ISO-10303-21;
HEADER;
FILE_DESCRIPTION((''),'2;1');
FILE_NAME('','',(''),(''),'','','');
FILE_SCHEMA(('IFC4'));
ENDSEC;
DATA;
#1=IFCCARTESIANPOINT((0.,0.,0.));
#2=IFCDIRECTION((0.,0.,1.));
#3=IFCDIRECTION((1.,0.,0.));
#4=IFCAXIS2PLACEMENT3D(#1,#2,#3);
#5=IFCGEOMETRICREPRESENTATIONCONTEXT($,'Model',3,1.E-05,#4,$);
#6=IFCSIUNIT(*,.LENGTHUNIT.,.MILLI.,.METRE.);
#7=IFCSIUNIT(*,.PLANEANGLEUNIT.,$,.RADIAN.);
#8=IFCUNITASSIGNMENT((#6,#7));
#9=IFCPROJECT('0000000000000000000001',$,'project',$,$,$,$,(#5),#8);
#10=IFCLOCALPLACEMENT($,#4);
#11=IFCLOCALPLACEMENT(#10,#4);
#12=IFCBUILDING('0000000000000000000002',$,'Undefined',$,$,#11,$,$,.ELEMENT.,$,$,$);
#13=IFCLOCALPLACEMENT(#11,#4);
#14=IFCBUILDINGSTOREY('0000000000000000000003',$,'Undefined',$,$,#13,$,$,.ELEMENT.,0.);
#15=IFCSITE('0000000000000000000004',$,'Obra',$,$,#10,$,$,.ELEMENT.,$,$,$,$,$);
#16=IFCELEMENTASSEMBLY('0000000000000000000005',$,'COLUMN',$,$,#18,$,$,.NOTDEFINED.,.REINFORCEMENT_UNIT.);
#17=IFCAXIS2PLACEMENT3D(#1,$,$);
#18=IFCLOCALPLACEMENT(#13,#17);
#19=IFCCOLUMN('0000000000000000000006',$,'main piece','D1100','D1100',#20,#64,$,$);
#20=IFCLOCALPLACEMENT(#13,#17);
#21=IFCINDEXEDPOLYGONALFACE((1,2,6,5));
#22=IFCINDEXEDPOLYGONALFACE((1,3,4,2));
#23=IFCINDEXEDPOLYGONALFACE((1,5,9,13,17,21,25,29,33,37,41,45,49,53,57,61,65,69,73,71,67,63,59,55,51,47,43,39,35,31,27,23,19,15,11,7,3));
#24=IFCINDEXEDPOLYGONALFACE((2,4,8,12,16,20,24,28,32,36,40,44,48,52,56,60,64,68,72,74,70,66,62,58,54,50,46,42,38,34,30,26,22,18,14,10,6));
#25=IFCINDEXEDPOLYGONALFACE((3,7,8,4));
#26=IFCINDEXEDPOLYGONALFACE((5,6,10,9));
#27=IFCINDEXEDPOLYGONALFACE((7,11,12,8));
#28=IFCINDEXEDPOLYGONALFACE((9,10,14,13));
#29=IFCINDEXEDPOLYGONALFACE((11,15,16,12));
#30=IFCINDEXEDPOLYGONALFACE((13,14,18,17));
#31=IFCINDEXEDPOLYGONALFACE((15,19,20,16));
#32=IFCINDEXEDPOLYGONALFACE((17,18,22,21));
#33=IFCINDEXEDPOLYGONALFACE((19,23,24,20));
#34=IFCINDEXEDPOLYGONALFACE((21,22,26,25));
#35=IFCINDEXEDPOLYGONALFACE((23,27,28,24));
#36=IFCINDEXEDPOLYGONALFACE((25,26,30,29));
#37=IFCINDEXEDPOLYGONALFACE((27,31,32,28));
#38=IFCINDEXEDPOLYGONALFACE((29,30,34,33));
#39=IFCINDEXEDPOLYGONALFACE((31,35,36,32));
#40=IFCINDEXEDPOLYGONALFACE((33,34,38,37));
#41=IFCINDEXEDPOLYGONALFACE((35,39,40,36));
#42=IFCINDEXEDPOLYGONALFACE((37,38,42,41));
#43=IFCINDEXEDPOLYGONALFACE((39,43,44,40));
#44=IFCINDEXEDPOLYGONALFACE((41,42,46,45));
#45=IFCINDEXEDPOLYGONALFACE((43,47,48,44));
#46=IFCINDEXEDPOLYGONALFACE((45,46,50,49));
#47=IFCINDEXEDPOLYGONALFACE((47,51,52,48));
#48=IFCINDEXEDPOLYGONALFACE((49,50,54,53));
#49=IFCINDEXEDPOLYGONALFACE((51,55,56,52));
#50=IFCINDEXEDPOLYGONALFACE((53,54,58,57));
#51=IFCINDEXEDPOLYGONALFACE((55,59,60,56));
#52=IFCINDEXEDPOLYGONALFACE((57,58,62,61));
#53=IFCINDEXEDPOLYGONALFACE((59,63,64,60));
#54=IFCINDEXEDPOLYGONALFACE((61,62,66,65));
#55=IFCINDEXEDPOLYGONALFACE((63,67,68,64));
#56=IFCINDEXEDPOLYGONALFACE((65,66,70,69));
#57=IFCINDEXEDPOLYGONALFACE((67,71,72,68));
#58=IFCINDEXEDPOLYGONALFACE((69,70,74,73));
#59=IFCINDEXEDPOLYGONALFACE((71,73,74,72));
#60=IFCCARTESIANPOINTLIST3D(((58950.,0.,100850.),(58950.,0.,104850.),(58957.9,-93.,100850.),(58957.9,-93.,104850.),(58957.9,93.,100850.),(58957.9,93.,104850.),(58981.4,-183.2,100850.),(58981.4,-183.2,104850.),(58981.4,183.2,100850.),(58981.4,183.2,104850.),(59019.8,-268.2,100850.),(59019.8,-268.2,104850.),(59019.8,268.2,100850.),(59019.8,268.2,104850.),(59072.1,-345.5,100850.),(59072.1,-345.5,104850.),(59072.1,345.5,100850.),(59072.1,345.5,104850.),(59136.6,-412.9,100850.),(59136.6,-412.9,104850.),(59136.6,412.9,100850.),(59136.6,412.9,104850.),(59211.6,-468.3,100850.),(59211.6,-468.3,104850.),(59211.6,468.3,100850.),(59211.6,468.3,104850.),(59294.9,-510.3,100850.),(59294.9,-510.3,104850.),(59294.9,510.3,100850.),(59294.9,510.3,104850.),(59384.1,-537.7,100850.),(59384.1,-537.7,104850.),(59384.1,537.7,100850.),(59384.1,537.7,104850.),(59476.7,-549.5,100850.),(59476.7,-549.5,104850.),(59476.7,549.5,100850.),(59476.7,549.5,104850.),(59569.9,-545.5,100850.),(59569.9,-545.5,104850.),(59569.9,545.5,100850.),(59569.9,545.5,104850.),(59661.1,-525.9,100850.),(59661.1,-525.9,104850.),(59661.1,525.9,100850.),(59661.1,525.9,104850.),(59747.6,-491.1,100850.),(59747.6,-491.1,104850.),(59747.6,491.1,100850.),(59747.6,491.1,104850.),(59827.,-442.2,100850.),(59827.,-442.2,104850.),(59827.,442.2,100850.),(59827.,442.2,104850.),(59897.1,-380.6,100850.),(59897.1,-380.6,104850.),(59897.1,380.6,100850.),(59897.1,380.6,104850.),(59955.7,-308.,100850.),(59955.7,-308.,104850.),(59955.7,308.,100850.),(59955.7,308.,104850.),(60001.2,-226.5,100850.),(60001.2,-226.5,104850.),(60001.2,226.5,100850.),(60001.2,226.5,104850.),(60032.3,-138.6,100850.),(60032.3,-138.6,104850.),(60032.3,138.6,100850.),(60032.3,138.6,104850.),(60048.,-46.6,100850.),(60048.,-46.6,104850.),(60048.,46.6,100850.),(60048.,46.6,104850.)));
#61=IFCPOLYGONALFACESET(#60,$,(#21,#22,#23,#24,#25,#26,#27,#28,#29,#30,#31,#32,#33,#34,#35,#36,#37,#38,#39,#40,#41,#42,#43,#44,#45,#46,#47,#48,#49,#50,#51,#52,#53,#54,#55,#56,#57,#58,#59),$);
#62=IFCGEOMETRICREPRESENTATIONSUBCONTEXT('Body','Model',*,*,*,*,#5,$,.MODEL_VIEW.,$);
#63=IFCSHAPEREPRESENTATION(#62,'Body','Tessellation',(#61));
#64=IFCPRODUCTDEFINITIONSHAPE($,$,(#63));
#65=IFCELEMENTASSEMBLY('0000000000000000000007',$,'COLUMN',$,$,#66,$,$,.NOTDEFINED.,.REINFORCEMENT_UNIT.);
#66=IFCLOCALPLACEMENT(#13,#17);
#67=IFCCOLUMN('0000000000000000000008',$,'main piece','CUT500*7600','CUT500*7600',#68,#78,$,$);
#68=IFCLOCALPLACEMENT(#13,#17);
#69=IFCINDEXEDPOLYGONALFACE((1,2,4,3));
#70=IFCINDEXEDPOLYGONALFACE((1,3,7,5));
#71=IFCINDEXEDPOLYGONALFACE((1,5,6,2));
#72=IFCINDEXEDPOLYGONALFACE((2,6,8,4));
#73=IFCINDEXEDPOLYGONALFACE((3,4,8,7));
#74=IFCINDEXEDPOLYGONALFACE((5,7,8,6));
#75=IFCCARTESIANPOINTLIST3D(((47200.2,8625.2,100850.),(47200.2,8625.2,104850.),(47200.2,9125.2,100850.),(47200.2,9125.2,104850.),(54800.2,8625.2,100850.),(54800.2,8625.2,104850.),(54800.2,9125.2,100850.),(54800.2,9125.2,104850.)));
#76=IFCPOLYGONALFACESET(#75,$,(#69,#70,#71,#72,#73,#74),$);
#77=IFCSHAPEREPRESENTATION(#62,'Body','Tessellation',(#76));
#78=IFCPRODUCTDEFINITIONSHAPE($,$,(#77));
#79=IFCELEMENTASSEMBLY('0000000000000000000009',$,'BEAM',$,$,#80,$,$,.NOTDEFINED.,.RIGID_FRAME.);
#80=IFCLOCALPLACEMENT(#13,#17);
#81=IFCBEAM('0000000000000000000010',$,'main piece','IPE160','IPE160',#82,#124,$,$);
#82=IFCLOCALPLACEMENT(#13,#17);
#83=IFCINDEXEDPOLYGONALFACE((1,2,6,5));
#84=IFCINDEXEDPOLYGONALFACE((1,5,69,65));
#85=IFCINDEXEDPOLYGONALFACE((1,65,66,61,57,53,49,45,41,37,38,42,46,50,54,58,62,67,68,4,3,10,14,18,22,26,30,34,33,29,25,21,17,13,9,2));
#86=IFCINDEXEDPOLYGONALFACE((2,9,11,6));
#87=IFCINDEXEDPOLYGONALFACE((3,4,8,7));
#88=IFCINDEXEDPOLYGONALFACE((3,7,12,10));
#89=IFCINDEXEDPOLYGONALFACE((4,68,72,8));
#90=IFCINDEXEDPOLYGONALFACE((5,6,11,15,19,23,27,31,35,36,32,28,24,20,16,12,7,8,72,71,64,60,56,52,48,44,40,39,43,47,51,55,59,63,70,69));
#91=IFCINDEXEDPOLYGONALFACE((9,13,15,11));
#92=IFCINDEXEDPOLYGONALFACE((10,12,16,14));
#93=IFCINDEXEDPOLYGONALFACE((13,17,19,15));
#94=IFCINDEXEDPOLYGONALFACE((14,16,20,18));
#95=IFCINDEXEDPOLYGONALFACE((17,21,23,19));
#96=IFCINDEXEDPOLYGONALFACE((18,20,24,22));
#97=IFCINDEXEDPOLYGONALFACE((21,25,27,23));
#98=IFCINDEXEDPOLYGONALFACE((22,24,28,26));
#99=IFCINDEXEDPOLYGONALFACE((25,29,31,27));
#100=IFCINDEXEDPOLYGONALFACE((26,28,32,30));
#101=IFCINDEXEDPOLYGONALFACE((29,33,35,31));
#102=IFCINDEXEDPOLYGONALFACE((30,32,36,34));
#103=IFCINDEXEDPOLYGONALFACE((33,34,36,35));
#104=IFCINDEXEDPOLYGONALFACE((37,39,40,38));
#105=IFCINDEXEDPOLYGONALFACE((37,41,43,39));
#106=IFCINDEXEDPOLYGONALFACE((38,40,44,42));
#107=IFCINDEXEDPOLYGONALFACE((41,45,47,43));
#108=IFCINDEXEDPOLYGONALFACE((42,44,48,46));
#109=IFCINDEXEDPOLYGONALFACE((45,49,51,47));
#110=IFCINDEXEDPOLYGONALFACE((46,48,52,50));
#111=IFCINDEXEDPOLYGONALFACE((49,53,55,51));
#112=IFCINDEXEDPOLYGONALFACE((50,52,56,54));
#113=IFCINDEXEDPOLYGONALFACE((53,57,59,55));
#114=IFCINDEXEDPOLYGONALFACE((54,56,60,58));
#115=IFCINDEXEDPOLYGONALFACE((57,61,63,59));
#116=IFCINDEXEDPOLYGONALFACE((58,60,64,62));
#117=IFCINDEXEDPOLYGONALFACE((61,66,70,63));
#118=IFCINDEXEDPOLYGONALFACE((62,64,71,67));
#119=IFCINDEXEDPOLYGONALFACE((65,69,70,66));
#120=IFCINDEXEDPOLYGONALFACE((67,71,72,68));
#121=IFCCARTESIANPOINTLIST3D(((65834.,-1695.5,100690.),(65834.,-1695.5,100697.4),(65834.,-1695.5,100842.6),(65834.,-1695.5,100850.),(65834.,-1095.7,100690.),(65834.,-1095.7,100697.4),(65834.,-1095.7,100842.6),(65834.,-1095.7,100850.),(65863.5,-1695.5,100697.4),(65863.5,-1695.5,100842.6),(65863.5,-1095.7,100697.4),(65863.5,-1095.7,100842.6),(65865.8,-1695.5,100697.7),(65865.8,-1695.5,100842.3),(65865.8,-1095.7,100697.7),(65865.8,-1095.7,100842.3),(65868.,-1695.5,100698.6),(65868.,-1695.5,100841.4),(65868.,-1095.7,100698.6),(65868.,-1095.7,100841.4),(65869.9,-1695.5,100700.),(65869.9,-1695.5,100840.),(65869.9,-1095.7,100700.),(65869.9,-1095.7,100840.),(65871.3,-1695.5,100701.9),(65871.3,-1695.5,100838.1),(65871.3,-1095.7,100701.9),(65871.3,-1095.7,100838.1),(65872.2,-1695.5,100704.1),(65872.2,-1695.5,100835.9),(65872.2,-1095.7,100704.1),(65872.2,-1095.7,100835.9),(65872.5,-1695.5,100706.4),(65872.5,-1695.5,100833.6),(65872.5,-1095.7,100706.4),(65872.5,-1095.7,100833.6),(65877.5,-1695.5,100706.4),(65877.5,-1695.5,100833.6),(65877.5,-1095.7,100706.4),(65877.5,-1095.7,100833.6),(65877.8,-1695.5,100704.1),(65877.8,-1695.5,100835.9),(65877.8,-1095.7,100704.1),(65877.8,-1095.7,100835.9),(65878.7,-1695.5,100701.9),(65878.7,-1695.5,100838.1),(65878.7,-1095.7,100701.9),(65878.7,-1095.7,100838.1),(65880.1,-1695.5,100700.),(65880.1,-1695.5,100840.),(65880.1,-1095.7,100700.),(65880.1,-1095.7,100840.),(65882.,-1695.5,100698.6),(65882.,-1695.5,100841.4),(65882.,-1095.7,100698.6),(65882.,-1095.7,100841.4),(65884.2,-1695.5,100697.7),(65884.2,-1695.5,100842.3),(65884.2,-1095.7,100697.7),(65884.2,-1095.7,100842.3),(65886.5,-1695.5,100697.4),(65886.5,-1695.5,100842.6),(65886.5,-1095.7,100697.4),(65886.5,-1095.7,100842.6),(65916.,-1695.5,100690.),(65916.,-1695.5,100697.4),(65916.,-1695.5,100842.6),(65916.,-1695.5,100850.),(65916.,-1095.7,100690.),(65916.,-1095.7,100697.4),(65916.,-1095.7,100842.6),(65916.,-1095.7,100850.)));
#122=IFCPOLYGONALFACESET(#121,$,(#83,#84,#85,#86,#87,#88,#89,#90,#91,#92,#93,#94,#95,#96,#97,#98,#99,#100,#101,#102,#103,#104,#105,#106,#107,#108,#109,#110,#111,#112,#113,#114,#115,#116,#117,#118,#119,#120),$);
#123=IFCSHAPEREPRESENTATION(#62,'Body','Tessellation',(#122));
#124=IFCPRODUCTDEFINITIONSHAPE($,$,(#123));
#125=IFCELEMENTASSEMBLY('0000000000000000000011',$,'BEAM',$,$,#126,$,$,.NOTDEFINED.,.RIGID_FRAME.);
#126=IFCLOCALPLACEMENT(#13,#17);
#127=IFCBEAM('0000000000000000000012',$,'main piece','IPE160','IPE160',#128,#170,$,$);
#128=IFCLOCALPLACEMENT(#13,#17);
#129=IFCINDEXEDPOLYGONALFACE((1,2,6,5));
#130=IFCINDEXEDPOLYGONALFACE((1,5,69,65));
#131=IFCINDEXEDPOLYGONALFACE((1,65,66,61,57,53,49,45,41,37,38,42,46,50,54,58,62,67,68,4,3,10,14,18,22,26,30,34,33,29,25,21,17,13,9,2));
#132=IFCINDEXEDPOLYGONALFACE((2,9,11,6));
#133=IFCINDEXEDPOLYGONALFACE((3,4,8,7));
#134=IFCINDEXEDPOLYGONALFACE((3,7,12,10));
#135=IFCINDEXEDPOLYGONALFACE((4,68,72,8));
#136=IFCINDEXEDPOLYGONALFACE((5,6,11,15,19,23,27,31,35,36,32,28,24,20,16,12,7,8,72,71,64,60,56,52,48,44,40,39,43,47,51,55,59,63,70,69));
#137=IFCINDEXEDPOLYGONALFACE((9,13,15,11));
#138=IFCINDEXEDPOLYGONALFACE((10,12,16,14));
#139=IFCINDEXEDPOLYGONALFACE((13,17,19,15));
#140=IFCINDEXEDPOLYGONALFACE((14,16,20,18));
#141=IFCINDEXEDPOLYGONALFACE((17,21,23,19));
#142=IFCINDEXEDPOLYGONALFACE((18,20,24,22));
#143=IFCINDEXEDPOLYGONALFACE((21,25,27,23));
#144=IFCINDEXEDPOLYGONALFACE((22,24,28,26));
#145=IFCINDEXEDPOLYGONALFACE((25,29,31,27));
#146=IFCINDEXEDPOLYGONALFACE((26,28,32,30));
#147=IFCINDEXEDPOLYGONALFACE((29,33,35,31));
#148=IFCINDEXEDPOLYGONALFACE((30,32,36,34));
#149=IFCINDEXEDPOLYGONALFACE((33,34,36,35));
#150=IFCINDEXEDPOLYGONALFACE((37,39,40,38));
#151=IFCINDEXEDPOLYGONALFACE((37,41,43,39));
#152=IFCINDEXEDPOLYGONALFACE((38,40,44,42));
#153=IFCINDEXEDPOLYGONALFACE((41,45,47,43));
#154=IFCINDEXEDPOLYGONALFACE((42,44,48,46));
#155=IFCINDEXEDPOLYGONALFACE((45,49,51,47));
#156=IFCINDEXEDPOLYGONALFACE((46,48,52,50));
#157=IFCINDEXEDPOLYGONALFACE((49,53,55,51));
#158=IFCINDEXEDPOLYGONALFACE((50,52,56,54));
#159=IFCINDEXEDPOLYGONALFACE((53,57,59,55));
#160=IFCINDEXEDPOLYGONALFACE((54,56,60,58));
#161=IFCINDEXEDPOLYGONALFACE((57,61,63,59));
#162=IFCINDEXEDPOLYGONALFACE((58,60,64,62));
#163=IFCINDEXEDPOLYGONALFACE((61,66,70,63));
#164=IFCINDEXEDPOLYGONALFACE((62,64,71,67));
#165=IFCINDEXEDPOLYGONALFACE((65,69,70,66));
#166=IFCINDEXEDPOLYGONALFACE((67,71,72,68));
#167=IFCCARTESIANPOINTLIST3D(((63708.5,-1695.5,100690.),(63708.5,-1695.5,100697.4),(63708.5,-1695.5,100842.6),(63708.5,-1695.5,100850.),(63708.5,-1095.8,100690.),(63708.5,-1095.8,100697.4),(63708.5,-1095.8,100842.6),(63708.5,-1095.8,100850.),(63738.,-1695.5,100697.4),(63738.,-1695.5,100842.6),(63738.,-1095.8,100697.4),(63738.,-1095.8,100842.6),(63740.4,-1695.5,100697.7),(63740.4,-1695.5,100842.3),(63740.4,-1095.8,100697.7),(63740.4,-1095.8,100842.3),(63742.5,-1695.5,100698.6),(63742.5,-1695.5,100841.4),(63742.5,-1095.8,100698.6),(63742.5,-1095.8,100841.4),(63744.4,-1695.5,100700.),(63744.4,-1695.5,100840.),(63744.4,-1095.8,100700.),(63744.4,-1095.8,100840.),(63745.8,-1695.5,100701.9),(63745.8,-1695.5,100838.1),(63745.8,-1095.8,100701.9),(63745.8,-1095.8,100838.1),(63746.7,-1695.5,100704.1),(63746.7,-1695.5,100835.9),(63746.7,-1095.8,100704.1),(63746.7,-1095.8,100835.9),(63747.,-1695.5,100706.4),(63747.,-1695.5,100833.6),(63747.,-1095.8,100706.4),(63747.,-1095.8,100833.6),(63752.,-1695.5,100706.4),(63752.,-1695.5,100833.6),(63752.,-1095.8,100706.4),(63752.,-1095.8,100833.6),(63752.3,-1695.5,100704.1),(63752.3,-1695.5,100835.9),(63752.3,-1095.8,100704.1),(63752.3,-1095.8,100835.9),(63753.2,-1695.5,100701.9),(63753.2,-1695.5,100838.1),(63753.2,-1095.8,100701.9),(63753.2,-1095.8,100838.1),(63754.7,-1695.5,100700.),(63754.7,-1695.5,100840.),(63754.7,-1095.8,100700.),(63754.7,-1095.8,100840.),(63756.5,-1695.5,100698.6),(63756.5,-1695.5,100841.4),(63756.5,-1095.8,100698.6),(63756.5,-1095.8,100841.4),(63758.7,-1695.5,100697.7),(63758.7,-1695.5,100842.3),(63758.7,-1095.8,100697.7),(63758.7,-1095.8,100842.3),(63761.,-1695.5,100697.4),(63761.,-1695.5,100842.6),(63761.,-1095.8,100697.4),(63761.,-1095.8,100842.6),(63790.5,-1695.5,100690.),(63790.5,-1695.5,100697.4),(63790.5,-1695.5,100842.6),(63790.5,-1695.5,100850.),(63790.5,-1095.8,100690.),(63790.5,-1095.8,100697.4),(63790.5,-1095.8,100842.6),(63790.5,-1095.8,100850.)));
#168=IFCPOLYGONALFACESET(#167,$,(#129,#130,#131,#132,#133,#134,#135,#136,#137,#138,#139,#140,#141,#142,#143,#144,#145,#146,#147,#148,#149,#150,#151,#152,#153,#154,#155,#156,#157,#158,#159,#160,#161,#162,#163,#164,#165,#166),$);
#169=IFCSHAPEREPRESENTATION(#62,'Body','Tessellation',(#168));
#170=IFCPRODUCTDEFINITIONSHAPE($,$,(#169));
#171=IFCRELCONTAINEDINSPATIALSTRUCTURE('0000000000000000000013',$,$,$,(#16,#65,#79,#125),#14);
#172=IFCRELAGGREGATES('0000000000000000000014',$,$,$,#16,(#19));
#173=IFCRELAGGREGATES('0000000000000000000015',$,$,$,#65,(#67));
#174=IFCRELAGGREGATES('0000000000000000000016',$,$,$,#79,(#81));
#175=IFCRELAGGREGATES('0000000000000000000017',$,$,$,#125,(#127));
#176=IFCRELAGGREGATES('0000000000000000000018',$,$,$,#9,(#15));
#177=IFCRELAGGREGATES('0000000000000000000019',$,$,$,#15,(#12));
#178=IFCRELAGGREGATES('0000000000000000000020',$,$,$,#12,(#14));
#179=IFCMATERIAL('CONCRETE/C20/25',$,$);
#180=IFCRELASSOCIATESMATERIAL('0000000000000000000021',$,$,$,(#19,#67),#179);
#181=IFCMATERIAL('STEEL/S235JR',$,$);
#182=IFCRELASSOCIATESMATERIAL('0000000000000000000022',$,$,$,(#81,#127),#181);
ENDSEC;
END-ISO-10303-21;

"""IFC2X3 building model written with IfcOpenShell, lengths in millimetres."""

from ifc_helpers import new_model, si_unit, frame, origin_with_axes, origin_2d_with_axis, place, context, subcontext, project, spatial, rectangle, circle, i_section, extrude, material, element, aggregate, save


model = new_model("IFC2X3")

# Units and contexts
model_context = context("Model", 3, precision=1e-05, world=origin_with_axes())
body_context = subcontext(model_context, "Body", "Model", "MODEL_VIEW")
ifc_project = project(units=[si_unit("LENGTHUNIT", "METRE", prefix="MILLI"), si_unit("PLANEANGLEUNIT", "RADIAN")], contexts=[model_context])

# Site, building, storey
site_placement = place(None, origin_with_axes())
site = spatial("IfcSite", under=ifc_project, at=site_placement, Name="Obra", CompositionType="ELEMENT")
building_placement = place(site_placement, origin_with_axes())
building = spatial("IfcBuilding", under=site, at=building_placement, Name="Undefined", CompositionType="ELEMENT")
storey_placement = place(building_placement, origin_with_axes())
storey = spatial("IfcBuildingStorey", under=building, at=storey_placement, Name="Undefined", CompositionType="ELEMENT", Elevation=0.0)

# Element assemblies, columns
assembly_1_placement = place(storey_placement, origin_with_axes())
assembly_1 = element("IfcElementAssembly", 1, at=assembly_1_placement, inside=storey, Name="COLUMN", AssemblyPlace="NOTDEFINED", PredefinedType="REINFORCEMENT_UNIT")
ifc_material_1 = material(Name="CONCRETE/C20/25")
column_1_placement = place(assembly_1_placement, frame((59500.0, 0.0, 100850.0), z_axis=(0.0, 0.0, 1.0), x_axis=(0.0, 1.0, 0.0)))
column_1 = element("IfcColumn", 2, at=column_1_placement, material=ifc_material_1, Name="main piece", Description="D1100", ObjectType="D1100", context=body_context, shape_type="SweptSolid", body=[
    extrude(circle(Radius=550.0, at=origin_2d_with_axis()), frame((0.0, 0.0, 4000.0), z_axis=(0.0, 0.0, -1.0), x_axis=(0.0, 1.0, 0.0)), (0.0, 0.0, 1.0), 4000.0),
])
aggregate(assembly_1, [column_1])
assembly_2_placement = place(storey_placement, origin_with_axes())
assembly_2 = element("IfcElementAssembly", 3, at=assembly_2_placement, inside=storey, Name="COLUMN", AssemblyPlace="NOTDEFINED", PredefinedType="REINFORCEMENT_UNIT")
column_2_placement = place(assembly_2_placement, frame((51000.2, 8875.2, 100850.0), z_axis=(0.0, 0.0, 1.0), x_axis=(-1.0, 0.0, 0.0)))
column_2 = element("IfcColumn", 4, at=column_2_placement, material=ifc_material_1, Name="main piece", Description="CUT500*7600", ObjectType="CUT500*7600", context=body_context, shape_type="SweptSolid", body=[
    extrude(rectangle(XDim=500.0, YDim=7600.0, at=origin_2d_with_axis()), frame((0.0, 0.0, 4000.0), z_axis=(0.0, 0.0, -1.0), x_axis=(0.0, 1.0, 0.0)), (0.0, 0.0, 1.0), 4000.0),
])
aggregate(assembly_2, [column_2])

# Element assemblies, beams
assembly_3_placement = place(storey_placement, origin_with_axes())
assembly_3 = element("IfcElementAssembly", 5, at=assembly_3_placement, inside=storey, Name="BEAM", AssemblyPlace="NOTDEFINED", PredefinedType="RIGID_FRAME")
ifc_material_2 = material(Name="STEEL/S235JR")
beam_1_placement = place(assembly_3_placement, frame((65875.0, -1095.7, 100770.0), z_axis=(0.0, 0.0, 1.0), x_axis=(0.0, -1.0, 0.0)))
beam_1 = element("IfcBeam", 6, at=beam_1_placement, material=ifc_material_2, Name="main piece", Description="IPE160", ObjectType="IPE160", context=body_context, shape_type="SweptSolid", body=[
    extrude(i_section(OverallWidth=82.0, OverallDepth=160.0, WebThickness=5.0, FlangeThickness=7.4, FilletRadius=9.0, at=origin_2d_with_axis()), frame((599.8, 0.0, 0.0), z_axis=(-1.0, 0.0, 0.0), x_axis=(0.0, -1.0, 0.0)), (0.0, 0.0, 1.0), 599.8),
])
aggregate(assembly_3, [beam_1])
assembly_4_placement = place(storey_placement, origin_with_axes())
assembly_4 = element("IfcElementAssembly", 7, at=assembly_4_placement, inside=storey, Name="BEAM", AssemblyPlace="NOTDEFINED", PredefinedType="RIGID_FRAME")
beam_2_placement = place(assembly_4_placement, frame((63749.5, -1095.8, 100770.0), z_axis=(0.0, 0.0, 1.0), x_axis=(0.0, -1.0, 0.0)))
beam_2 = element("IfcBeam", 8, at=beam_2_placement, material=ifc_material_2, Name="main piece", Description="IPE160", ObjectType="IPE160", context=body_context, shape_type="SweptSolid", body=[
    extrude(i_section(OverallWidth=82.0, OverallDepth=160.0, WebThickness=5.0, FlangeThickness=7.4, FilletRadius=9.0, at=origin_2d_with_axis()), frame((599.7, 0.0, 0.0), z_axis=(-1.0, 0.0, 0.0), x_axis=(0.0, -1.0, 0.0)), (0.0, 0.0, 1.0), 599.7),
])
aggregate(assembly_4, [beam_2])

save(model, "model.ifc")
